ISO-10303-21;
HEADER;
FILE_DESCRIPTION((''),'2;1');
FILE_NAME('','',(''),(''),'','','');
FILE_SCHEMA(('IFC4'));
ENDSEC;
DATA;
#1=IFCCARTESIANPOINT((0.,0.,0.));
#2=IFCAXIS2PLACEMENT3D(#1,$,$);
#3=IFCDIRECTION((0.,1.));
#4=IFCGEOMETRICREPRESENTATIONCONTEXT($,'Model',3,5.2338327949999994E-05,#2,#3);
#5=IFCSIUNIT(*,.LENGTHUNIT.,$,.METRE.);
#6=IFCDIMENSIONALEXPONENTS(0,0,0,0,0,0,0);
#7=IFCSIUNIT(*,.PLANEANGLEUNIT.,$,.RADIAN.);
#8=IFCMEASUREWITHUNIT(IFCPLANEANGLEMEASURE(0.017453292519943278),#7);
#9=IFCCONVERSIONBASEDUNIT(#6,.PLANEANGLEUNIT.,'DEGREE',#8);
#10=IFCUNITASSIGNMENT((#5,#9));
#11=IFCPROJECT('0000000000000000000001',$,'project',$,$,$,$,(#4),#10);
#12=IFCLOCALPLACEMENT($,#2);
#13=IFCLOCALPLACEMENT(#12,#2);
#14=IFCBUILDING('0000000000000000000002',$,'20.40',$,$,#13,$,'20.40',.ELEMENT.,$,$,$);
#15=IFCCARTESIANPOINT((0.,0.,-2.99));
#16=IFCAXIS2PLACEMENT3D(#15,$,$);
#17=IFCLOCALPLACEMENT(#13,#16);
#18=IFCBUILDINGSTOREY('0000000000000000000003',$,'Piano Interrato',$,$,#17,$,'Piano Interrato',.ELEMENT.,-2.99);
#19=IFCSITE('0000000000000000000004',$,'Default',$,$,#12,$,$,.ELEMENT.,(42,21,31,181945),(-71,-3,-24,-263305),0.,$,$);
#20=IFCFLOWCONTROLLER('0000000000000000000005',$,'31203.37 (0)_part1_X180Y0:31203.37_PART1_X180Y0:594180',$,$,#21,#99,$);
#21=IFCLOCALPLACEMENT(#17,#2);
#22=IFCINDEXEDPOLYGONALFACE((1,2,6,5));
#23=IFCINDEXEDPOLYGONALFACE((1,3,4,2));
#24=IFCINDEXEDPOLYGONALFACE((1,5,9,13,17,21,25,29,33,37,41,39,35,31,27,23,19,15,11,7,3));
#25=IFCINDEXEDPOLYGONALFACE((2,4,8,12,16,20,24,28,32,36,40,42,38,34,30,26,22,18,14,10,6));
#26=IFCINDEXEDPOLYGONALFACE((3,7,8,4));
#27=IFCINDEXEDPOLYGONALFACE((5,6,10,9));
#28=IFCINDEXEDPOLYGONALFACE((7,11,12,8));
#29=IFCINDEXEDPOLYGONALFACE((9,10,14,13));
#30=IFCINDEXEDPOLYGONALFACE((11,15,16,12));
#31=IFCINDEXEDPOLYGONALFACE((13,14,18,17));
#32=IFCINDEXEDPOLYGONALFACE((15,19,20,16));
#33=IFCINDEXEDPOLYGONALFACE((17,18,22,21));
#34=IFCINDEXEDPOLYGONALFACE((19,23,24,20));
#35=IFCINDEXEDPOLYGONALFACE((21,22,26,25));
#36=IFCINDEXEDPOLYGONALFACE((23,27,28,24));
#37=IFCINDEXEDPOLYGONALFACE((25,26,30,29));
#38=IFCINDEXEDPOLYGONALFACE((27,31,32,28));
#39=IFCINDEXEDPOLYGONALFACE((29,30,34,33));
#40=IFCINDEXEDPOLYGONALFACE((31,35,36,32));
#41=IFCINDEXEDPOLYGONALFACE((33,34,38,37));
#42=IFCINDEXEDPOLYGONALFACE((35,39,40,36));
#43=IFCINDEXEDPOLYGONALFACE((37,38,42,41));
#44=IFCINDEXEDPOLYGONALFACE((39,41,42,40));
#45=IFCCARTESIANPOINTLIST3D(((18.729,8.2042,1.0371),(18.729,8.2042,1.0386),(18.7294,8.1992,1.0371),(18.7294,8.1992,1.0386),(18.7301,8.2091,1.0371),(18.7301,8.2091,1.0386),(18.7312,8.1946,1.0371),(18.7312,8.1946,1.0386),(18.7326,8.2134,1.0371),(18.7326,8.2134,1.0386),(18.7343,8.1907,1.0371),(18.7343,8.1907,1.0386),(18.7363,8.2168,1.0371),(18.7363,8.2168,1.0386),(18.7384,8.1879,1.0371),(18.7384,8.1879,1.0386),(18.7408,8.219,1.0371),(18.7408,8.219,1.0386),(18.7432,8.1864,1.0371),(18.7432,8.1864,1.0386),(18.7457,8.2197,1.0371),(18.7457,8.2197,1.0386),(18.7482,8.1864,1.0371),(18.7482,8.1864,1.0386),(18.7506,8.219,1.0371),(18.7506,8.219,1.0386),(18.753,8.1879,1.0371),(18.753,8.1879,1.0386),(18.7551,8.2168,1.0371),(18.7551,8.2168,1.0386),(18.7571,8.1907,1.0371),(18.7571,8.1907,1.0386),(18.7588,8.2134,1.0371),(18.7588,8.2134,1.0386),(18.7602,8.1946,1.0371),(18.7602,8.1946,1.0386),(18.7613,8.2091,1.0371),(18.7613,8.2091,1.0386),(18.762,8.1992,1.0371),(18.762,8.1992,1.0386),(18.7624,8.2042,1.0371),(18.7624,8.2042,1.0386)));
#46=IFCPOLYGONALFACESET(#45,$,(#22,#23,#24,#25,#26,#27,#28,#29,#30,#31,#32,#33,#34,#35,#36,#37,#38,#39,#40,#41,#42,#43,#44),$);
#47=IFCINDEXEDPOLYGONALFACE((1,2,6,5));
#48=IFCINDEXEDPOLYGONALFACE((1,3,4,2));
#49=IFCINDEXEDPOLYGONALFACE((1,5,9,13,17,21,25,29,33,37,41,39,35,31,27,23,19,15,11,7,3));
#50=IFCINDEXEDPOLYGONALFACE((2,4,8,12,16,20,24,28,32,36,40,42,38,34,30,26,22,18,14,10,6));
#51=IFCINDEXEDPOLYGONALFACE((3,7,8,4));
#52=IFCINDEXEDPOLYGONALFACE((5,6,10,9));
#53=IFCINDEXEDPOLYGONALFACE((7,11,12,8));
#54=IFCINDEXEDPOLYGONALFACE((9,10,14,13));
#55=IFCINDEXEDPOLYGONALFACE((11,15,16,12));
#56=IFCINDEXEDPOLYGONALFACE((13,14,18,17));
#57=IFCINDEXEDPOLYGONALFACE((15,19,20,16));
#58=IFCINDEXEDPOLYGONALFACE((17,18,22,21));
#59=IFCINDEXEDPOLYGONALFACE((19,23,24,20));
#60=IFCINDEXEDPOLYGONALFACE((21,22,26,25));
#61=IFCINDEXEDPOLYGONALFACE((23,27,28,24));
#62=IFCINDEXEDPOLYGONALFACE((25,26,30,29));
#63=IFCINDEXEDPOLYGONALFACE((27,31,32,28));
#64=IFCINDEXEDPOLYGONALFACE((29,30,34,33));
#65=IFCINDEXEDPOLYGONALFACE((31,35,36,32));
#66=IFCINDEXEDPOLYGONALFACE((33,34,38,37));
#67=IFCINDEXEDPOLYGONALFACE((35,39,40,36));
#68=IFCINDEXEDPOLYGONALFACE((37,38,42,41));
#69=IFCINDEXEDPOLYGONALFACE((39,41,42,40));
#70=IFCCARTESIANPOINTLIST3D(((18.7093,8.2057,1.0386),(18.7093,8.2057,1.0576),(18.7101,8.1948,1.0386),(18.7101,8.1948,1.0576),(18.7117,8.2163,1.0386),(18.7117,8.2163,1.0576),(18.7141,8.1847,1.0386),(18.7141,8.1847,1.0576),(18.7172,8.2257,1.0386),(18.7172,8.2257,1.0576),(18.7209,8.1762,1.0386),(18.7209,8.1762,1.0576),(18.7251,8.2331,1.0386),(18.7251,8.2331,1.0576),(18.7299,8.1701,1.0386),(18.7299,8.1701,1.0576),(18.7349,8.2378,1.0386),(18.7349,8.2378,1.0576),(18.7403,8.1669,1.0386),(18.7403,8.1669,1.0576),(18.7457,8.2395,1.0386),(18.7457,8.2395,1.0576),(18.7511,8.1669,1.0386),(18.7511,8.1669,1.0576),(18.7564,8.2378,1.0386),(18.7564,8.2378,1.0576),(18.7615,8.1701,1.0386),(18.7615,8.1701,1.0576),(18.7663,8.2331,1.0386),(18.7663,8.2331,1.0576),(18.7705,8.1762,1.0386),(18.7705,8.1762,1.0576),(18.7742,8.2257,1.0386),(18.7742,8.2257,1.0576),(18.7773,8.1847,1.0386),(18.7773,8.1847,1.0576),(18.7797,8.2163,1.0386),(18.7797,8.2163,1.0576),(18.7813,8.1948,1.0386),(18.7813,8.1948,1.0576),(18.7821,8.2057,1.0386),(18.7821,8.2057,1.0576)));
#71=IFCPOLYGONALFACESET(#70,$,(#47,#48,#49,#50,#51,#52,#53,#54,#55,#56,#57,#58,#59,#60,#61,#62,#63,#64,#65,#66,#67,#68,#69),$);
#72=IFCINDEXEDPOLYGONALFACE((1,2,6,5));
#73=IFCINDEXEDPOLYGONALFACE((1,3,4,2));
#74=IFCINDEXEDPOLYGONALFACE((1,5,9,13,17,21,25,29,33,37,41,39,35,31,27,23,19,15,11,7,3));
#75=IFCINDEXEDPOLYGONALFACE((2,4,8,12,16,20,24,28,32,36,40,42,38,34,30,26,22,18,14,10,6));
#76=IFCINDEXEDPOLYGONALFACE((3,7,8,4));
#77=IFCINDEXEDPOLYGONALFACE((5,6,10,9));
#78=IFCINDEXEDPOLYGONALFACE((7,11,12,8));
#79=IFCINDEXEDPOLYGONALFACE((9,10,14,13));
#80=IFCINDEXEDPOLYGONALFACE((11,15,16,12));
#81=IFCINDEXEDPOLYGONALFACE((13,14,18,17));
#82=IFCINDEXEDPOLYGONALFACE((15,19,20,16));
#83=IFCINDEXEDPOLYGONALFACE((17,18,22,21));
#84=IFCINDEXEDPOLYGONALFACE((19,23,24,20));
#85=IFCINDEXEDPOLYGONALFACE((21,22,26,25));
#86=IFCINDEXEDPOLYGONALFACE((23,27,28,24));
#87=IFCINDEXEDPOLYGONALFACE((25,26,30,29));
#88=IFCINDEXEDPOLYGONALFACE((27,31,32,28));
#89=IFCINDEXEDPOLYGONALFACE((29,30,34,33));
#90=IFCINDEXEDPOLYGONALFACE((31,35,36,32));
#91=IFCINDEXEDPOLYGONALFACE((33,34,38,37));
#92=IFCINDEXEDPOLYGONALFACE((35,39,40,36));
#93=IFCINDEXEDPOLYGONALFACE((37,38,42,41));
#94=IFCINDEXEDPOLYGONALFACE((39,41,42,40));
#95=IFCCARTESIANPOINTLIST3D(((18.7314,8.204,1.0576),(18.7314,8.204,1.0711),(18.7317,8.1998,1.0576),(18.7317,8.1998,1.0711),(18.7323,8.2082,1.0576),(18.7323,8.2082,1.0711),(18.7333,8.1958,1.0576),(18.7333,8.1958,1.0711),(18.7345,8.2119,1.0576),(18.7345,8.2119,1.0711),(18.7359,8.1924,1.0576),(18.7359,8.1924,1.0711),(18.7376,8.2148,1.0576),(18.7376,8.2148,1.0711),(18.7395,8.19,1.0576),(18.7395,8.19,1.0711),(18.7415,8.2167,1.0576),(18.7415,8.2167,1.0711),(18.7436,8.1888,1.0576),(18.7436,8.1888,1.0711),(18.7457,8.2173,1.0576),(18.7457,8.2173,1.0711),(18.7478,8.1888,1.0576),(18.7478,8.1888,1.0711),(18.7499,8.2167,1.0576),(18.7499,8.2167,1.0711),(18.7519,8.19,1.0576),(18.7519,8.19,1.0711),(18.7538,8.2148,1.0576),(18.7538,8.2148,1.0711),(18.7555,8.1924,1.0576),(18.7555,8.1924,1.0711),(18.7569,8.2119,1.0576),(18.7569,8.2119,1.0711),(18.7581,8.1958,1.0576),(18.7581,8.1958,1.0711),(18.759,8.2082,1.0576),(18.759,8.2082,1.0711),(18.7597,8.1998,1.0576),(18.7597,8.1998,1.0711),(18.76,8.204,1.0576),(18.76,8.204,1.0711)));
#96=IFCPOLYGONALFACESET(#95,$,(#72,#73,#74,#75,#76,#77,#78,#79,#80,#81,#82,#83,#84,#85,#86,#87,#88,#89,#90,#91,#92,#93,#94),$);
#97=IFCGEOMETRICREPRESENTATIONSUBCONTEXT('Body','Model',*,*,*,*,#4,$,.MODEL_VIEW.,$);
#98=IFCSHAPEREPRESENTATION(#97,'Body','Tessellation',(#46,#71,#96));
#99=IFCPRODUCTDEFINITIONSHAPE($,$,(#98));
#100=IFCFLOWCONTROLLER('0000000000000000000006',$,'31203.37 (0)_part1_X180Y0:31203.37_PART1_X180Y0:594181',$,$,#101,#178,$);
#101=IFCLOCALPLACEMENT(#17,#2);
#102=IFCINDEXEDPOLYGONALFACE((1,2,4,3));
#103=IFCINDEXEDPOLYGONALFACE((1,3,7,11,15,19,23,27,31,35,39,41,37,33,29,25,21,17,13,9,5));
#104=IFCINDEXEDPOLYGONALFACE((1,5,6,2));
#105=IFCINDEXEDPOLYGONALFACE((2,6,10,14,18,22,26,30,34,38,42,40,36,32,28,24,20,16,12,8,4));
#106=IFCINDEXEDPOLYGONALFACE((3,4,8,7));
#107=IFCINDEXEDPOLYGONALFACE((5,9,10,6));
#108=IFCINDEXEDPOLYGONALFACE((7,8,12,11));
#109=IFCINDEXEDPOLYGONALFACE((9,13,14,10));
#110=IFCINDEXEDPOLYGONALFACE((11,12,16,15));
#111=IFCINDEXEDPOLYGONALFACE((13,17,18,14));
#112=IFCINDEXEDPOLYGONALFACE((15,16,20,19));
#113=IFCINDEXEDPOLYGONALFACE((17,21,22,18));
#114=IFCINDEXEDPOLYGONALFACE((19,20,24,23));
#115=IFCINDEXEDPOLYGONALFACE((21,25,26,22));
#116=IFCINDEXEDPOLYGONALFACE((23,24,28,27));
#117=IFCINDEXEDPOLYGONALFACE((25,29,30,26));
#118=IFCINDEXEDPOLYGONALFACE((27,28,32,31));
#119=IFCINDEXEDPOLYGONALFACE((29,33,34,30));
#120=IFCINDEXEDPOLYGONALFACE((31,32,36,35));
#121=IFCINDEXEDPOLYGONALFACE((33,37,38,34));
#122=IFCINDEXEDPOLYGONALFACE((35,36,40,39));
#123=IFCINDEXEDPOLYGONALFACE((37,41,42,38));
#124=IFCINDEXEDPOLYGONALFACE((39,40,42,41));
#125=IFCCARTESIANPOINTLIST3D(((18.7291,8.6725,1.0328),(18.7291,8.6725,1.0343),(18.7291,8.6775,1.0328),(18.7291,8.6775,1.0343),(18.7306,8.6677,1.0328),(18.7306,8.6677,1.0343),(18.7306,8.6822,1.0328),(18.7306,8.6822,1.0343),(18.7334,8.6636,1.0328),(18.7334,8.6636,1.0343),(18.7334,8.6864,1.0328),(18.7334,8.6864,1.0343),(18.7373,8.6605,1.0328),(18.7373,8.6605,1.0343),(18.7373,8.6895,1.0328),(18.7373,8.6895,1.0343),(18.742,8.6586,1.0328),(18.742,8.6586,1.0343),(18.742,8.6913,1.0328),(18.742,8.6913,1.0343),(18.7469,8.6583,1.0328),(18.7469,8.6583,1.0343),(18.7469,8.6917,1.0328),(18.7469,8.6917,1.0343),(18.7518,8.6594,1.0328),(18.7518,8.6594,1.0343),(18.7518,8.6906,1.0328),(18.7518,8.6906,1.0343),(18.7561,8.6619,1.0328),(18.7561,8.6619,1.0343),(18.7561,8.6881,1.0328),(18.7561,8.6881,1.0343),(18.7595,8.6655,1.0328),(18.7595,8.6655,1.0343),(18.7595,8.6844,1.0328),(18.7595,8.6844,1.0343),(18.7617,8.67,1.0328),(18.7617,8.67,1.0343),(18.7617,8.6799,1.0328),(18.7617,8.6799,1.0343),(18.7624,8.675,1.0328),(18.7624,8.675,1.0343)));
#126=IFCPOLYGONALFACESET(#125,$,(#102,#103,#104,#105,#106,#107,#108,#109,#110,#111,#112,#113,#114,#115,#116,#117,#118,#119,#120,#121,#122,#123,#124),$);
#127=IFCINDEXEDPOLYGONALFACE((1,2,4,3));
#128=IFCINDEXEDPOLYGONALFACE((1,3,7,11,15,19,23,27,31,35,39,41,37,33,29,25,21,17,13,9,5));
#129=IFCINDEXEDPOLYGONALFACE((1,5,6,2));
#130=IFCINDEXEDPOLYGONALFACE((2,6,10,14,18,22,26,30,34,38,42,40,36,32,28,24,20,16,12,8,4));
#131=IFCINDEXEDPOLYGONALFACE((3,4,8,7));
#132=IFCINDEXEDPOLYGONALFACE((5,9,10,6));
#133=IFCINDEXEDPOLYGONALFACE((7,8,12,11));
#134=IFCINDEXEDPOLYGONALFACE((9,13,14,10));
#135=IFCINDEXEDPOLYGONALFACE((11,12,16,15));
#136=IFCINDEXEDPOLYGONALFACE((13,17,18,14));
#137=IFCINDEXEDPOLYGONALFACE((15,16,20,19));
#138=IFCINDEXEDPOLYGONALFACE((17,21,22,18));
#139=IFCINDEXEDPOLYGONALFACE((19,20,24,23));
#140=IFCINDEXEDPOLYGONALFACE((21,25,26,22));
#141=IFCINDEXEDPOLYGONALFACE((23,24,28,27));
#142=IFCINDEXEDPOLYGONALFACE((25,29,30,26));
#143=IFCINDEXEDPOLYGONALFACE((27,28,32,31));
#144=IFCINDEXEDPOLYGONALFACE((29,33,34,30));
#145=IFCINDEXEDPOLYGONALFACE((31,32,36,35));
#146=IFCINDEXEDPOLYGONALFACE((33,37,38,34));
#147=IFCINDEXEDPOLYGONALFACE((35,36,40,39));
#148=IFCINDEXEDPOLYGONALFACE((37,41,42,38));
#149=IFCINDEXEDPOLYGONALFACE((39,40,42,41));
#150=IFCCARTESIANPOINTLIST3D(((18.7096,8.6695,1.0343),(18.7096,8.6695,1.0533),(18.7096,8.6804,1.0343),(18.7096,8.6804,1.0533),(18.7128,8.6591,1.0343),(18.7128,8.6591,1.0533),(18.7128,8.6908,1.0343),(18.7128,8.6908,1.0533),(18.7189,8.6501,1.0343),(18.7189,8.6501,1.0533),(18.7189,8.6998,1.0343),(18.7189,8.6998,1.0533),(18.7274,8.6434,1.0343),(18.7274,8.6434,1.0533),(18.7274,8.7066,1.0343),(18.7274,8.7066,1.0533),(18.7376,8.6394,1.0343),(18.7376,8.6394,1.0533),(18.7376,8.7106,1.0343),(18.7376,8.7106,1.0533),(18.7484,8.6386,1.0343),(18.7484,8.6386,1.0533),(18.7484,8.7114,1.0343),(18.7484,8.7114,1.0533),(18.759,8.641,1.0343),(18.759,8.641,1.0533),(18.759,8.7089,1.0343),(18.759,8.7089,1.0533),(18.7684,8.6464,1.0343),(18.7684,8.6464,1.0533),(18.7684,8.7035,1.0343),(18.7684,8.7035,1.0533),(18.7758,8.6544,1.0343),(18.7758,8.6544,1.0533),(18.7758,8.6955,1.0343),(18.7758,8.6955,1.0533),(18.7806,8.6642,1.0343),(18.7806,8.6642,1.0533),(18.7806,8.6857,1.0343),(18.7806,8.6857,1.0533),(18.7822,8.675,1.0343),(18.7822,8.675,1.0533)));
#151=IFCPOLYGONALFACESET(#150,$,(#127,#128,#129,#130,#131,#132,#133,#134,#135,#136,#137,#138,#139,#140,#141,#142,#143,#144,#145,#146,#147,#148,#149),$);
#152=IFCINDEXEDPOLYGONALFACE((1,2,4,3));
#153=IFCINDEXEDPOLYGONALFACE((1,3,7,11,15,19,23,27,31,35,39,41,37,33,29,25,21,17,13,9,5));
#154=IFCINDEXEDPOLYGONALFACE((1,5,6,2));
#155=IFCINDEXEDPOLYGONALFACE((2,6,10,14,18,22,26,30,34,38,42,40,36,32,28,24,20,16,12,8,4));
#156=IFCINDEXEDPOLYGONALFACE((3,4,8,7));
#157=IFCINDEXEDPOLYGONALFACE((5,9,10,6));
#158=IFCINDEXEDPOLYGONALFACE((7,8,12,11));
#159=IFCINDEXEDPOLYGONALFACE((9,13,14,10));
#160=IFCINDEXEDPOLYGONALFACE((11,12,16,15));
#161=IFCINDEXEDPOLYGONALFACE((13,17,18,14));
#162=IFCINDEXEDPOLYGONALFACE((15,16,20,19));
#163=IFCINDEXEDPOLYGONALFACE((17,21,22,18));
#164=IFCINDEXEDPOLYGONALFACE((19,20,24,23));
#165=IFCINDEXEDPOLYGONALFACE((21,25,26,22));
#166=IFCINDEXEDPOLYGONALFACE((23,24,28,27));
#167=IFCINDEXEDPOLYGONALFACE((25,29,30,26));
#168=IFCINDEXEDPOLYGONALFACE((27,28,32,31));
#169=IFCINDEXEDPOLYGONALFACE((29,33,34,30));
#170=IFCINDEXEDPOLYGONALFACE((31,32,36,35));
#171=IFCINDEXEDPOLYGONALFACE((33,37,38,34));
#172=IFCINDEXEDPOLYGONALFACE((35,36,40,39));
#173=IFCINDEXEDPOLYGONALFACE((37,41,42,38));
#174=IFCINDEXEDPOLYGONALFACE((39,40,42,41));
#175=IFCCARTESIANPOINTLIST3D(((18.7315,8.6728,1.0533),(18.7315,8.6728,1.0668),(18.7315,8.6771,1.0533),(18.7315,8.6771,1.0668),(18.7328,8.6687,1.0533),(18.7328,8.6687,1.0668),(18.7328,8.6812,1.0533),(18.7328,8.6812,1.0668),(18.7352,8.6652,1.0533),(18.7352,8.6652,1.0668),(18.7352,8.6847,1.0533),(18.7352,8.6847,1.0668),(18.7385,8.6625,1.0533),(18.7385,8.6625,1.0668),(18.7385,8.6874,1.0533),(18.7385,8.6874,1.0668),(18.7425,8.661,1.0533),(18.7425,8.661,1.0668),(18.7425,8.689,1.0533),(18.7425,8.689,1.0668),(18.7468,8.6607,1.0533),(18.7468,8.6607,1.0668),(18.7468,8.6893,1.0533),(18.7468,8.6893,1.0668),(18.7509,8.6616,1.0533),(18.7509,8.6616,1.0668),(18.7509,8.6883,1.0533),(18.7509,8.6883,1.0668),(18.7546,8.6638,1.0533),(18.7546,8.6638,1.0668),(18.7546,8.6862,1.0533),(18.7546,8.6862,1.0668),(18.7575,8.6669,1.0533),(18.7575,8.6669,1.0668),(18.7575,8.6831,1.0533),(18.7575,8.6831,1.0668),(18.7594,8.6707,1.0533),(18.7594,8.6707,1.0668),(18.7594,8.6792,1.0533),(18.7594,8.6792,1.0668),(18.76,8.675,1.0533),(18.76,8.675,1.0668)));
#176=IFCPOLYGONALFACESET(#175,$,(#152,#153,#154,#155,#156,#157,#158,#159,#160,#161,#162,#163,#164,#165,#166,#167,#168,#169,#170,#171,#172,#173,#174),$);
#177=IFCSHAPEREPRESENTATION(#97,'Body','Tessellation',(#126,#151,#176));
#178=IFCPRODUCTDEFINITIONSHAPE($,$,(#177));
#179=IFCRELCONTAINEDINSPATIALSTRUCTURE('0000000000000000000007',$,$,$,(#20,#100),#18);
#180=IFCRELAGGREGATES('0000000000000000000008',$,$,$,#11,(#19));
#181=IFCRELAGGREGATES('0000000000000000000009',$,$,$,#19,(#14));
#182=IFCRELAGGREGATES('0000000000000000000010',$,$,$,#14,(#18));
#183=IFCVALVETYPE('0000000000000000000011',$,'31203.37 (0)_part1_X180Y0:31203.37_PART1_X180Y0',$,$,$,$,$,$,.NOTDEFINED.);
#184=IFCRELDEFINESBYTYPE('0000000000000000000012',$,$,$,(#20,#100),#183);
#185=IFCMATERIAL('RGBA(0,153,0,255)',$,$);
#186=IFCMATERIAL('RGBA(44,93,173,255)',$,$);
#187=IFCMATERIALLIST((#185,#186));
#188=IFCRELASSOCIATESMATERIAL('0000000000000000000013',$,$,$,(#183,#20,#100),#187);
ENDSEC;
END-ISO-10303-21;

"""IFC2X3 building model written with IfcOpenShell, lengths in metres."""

from ifc_helpers import new_model, entity, si_unit, converted_unit, direction, frame, frame_2d, origin, place, context, subcontext, project, spatial, circle, extrude, source, transform, mapped, material, material_list, type_object, type_shapes, element, save


model = new_model("IFC2X3")

# Units and contexts
model_context = context("Model", 3, precision=5.2338327949999994e-05, world=origin(), true_north=direction((0.0, 1.0)))
body_context = subcontext(model_context, "Body", "Model", "MODEL_VIEW")
ifc_project = project(units=[si_unit("LENGTHUNIT", "METRE"), converted_unit("PLANEANGLEUNIT", "DEGREE", entity("IfcPlaneAngleMeasure", 0.017453292519943278), si_unit("PLANEANGLEUNIT", "RADIAN"), dimensions=[0, 0, 0, 0, 0, 0, 0])], contexts=[model_context])

# Site, building, storey
site_placement = place(None, origin())
site = spatial("IfcSite", under=ifc_project, at=site_placement, Name="Default", CompositionType="ELEMENT", RefLatitude=(42, 21, 31, 181945), RefLongitude=(-71, -3, -24, -263305), RefElevation=0.0)
building_placement = place(site_placement, origin())
building = spatial("IfcBuilding", under=site, at=building_placement, Name="20.40", LongName="20.40", CompositionType="ELEMENT")
storey_placement = place(building_placement, frame((0.0, 0.0, -2.99)))
storey = spatial("IfcBuildingStorey", under=building, at=storey_placement, Name="Piano Interrato", LongName="Piano Interrato", CompositionType="ELEMENT", Elevation=-2.99)

# Flow controllers
ifc_material_1 = material(Name="RGBA(0,153,0,255)")
ifc_material_2 = material(Name="RGBA(44,93,173,255)")
ifc_material_list_1 = material_list([ifc_material_1, ifc_material_2])
valve_type_1 = type_object("IfcValveType", Name="31203.37 (0)_part1_X180Y0:31203.37_PART1_X180Y0", PredefinedType="NOTDEFINED", material=ifc_material_list_1)
shared_shape_1 = source(origin(), body_context, "Body", "SweptSolid", [
    extrude(circle(Radius=0.0168, at=frame_2d((0.0, 0.0), x_axis=(1.0, 0.0))), frame((0.0, 0.0, -0.034), z_axis=(0.0, 0.0, 1.0), x_axis=(0.0, -1.0, 0.0)), (0.0, 0.0, 1.0), 0.0015),
    extrude(circle(Radius=0.0365, at=frame_2d((0.0, 0.0), x_axis=(1.0, 0.0))), frame((0.0, 0.0, -0.0325), z_axis=(0.0, 0.0, 1.0), x_axis=(0.0, -1.0, 0.0)), (0.0, 0.0, 1.0), 0.019),
    extrude(circle(Radius=0.0144, at=frame_2d((0.0, 0.0), x_axis=(1.0, 0.0))), frame((0.0, 0.0, -0.0135), z_axis=(0.0, 0.0, 1.0), x_axis=(0.0, -1.0, 0.0)), (0.0, 0.0, 1.0), 0.0135),
])
type_shapes(valve_type_1, [shared_shape_1])
for number, where, z_axis, x_axis, name in (
    (1, (18.7457, 8.203, 1.0711), (0.0, 0.0, 1.0), (-1.0, 0.0, 0.0), "31203.37 (0)_part1_X180Y0:31203.37_PART1_X180Y0:594180"),
    (2, (18.7457, 8.675, 1.0668), (0.0, 0.0, 1.0), (0.0, 1.0, 0.0), "31203.37 (0)_part1_X180Y0:31203.37_PART1_X180Y0:594181"),
):
    element("IfcFlowController", number, at=place(storey_placement, frame(where, z_axis=z_axis, x_axis=x_axis)), inside=storey, type_object=valve_type_1, material=ifc_material_list_1, Name=name, context=body_context, shape_type="MappedRepresentation", body=[
        mapped(shared_shape_1, transform((0.0, 0.0, 0.0), scale=1.0)),
    ])

save(model, "model.ifc")
